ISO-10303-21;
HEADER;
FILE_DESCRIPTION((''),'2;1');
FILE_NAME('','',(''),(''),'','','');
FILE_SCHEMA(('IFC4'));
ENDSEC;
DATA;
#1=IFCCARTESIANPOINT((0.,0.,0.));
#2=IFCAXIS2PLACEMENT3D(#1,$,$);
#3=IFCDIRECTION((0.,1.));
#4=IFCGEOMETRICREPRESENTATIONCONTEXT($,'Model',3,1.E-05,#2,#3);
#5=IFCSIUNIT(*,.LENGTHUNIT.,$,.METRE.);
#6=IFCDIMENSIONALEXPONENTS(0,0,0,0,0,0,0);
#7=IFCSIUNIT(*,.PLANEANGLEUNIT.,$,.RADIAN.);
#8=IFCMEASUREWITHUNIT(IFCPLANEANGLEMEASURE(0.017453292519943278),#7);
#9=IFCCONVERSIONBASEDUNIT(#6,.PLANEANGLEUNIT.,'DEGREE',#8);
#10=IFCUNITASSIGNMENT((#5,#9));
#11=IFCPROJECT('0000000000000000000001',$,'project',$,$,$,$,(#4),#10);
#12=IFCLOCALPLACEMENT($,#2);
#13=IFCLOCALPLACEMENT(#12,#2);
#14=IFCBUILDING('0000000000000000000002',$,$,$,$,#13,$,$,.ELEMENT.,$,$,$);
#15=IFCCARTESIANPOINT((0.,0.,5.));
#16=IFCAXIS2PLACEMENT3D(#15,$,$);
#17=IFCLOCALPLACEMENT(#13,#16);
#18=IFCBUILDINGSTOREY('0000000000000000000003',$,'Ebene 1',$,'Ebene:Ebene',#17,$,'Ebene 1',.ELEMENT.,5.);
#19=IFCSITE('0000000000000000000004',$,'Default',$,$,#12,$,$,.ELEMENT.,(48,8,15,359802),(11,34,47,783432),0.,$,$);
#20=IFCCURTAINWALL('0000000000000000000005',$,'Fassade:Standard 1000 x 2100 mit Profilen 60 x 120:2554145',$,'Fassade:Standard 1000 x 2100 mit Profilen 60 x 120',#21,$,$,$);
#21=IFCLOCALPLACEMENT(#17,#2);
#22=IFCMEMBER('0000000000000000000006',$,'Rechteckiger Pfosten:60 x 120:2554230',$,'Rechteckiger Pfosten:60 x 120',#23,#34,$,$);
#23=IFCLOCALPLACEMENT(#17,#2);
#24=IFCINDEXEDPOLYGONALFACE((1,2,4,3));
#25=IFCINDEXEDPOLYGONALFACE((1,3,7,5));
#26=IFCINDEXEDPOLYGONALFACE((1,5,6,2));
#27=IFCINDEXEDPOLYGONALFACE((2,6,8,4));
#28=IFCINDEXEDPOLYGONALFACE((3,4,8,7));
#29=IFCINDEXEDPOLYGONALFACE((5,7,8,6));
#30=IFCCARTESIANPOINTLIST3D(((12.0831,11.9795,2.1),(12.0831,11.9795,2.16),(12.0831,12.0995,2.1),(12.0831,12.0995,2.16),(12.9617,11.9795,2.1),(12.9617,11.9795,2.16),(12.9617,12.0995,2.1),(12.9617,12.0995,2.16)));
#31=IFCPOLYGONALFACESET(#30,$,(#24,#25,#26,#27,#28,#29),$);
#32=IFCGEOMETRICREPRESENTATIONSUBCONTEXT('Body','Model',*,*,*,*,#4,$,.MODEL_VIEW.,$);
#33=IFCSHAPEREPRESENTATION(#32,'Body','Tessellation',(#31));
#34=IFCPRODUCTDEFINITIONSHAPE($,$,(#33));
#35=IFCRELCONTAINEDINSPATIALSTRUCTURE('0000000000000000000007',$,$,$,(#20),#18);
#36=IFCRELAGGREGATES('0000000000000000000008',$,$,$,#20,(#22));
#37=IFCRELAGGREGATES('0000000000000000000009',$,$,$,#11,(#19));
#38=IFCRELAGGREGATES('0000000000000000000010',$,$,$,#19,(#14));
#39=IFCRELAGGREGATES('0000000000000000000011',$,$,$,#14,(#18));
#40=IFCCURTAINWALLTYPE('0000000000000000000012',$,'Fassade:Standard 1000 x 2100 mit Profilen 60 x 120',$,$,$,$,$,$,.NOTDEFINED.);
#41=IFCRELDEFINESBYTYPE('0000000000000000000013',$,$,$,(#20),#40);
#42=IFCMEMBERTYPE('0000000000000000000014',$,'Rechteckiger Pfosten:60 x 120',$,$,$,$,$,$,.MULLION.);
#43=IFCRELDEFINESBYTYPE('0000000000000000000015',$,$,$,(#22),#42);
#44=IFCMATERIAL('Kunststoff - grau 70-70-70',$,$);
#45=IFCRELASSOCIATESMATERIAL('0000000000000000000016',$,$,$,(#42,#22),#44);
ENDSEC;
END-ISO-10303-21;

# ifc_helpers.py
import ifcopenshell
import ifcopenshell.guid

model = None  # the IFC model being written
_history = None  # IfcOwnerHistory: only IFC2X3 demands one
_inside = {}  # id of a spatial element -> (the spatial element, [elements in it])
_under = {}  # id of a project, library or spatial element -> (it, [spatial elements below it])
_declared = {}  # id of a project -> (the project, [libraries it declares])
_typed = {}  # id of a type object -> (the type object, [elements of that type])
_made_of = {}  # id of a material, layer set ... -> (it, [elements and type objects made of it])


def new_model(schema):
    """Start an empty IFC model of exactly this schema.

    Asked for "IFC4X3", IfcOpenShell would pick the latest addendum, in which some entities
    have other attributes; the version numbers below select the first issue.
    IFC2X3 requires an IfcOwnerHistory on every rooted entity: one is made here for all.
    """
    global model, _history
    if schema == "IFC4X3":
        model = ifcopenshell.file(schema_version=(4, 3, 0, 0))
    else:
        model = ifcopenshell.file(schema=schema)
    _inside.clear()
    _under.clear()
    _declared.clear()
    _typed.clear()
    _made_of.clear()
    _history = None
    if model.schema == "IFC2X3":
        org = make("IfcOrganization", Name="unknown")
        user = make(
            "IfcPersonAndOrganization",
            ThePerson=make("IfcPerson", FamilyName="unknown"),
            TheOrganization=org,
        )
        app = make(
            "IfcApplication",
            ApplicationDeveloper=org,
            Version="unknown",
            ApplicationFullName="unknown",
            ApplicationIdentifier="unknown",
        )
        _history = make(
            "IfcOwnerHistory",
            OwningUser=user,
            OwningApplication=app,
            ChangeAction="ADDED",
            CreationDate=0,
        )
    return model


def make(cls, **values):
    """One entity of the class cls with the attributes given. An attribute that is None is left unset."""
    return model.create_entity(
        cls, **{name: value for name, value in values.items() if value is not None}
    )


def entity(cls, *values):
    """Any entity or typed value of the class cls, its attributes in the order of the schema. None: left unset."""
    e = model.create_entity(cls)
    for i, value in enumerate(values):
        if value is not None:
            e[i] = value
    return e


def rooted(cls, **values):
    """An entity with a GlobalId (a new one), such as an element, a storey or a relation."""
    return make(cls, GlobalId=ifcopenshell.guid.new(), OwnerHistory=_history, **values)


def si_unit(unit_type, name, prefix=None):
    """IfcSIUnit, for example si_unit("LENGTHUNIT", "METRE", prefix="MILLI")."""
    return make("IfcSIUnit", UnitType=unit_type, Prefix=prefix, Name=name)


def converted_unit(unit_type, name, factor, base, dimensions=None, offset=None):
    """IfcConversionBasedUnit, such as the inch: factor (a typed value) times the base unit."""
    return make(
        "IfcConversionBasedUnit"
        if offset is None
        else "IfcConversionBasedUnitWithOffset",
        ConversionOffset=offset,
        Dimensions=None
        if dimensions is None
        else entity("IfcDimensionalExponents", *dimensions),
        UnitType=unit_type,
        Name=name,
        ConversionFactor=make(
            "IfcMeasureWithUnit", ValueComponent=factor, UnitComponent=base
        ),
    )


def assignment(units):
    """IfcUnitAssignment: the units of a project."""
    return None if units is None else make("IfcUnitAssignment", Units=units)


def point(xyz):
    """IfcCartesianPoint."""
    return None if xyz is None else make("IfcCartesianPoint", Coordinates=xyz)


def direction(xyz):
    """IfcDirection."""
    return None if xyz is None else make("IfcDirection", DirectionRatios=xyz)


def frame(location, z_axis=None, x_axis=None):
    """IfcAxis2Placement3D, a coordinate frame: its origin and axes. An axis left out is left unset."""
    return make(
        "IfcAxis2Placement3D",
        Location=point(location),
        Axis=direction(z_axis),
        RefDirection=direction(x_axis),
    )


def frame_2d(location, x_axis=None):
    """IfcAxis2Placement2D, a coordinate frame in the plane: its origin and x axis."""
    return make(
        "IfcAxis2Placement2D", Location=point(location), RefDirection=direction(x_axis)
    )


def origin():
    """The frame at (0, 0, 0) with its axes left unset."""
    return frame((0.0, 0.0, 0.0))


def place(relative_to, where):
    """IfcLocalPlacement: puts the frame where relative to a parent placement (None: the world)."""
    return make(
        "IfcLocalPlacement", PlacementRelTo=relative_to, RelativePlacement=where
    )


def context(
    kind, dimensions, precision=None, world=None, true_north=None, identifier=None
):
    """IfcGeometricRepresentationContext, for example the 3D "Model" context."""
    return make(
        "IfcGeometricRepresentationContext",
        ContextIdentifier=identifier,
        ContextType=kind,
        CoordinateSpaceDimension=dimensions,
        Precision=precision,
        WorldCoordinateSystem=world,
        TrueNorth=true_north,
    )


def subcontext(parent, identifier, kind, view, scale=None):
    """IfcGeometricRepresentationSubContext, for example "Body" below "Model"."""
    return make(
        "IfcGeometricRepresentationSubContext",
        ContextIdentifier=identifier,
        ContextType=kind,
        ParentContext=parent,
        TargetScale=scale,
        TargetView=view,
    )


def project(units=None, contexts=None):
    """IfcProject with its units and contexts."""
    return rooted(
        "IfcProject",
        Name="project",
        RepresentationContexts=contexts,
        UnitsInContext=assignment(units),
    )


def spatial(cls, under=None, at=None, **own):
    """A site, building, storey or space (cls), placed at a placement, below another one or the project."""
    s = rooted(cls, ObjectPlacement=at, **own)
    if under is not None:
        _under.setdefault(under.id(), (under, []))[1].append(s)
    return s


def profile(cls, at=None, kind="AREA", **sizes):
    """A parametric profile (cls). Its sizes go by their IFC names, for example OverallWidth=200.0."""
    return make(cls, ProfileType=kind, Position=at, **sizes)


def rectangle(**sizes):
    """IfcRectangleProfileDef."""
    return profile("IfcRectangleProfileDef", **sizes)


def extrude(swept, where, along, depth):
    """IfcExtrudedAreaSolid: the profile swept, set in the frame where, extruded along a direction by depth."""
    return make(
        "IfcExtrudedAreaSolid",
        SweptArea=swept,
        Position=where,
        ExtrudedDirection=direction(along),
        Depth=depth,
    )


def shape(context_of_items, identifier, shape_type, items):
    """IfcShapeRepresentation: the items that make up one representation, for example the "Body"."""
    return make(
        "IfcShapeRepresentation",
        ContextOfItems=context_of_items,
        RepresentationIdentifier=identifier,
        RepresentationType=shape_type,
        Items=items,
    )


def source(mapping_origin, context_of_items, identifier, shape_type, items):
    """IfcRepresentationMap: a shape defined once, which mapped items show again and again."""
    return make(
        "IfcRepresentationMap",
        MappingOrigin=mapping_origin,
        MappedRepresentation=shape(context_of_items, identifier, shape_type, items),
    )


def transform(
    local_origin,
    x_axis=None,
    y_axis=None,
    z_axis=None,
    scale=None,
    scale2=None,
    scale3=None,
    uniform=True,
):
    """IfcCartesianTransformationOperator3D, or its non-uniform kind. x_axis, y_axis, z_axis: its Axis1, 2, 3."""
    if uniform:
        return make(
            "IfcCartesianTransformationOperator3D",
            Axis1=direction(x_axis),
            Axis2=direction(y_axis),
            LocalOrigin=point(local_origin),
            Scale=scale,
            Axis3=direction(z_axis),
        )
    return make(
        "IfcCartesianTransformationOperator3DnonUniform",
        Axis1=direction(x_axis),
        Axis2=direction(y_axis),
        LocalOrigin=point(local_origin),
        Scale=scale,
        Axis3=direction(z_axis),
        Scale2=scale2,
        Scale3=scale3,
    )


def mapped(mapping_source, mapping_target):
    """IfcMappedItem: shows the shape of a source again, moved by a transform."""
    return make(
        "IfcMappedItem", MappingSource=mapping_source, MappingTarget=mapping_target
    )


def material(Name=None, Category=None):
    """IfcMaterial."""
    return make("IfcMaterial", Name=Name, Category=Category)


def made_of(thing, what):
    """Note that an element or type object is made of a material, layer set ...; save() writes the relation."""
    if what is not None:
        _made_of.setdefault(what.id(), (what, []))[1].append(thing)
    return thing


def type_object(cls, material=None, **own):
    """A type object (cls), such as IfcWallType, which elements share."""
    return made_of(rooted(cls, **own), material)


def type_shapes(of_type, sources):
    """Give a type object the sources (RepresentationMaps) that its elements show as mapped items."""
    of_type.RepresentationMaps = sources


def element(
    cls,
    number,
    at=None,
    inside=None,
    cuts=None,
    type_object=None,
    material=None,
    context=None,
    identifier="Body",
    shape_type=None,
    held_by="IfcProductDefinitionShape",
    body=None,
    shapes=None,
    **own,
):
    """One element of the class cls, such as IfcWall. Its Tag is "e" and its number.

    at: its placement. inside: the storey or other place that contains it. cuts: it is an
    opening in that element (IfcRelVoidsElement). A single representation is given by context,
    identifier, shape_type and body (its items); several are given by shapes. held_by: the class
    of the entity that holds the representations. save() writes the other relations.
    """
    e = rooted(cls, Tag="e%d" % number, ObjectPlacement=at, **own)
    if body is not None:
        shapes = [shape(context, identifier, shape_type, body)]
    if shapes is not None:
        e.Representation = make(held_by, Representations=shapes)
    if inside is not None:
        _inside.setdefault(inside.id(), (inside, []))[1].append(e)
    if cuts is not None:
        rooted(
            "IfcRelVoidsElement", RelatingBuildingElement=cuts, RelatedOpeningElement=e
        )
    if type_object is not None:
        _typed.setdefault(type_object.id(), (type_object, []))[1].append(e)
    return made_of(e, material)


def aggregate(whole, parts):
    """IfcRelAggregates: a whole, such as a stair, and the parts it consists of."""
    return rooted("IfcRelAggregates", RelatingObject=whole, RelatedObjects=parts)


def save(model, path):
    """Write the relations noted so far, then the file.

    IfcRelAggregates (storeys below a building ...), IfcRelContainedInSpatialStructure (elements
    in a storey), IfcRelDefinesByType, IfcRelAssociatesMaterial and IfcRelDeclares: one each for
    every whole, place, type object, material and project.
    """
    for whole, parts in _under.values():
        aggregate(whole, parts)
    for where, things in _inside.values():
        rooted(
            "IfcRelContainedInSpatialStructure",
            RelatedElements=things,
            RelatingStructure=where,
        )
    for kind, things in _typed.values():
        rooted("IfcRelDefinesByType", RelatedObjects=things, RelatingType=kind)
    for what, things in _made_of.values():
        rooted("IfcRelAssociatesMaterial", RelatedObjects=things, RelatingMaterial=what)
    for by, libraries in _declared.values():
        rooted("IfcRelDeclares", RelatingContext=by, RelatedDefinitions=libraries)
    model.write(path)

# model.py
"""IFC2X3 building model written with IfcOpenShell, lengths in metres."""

from ifc_helpers import new_model, entity, si_unit, converted_unit, direction, frame, frame_2d, origin, place, context, subcontext, project, spatial, rectangle, extrude, source, transform, mapped, material, type_object, type_shapes, element, aggregate, save


model = new_model("IFC2X3")

# Units and contexts
model_context = context("Model", 3, precision=1e-05, world=origin(), true_north=direction((0.0, 1.0)))
body_context = subcontext(model_context, "Body", "Model", "MODEL_VIEW")
ifc_project = project(units=[si_unit("LENGTHUNIT", "METRE"), converted_unit("PLANEANGLEUNIT", "DEGREE", entity("IfcPlaneAngleMeasure", 0.017453292519943278), si_unit("PLANEANGLEUNIT", "RADIAN"), dimensions=[0, 0, 0, 0, 0, 0, 0])], contexts=[model_context])

# Site, building, storey
site_placement = place(None, origin())
site = spatial("IfcSite", under=ifc_project, at=site_placement, Name="Default", CompositionType="ELEMENT", RefLatitude=(48, 8, 15, 359802), RefLongitude=(11, 34, 47, 783432), RefElevation=0.0)
building_placement = place(site_placement, origin())
building = spatial("IfcBuilding", under=site, at=building_placement, CompositionType="ELEMENT")
storey_placement = place(building_placement, frame((0.0, 0.0, 5.0)))
storey = spatial("IfcBuildingStorey", under=building, at=storey_placement, Name="Ebene 1", ObjectType="Ebene:Ebene", LongName="Ebene 1", CompositionType="ELEMENT", Elevation=5.0)

# Curtain wall
curtain_wall_type = type_object("IfcCurtainWallType", Name="Fassade:Standard 1000 x 2100 mit Profilen 60 x 120", PredefinedType="NOTDEFINED")
ifc_material_1 = material(Name="Kunststoff - grau 70-70-70")
curtain_wall_1_placement = place(storey_placement, frame((0.0, 0.0, -5.0)))
curtain_wall_1 = element("IfcCurtainWall", 1, at=curtain_wall_1_placement, inside=storey, type_object=curtain_wall_type, Name="Fassade:Standard 1000 x 2100 mit Profilen 60 x 120:2554145", ObjectType="Fassade:Standard 1000 x 2100 mit Profilen 60 x 120")

# Member
member_type_1 = type_object("IfcMemberType", Name="Rechteckiger Pfosten:60 x 120", PredefinedType="MULLION", material=ifc_material_1)
shared_shape_1 = source(origin(), body_context, "Body", "SweptSolid", [
    extrude(rectangle(XDim=0.06, YDim=0.12, at=frame_2d((0.0, 0.0), x_axis=(1.0, 0.0))), frame((0.0, 0.0, -0.8786), z_axis=(0.0, 0.0, 1.0), x_axis=(-1.0, 0.0, 0.0)), (0.0, 0.0, 1.0), 0.8786),
])
type_shapes(member_type_1, [shared_shape_1])
member_1_placement = place(curtain_wall_1_placement, frame((12.0831, 12.0395, 7.13), z_axis=(-1.0, 0.0, 0.0), x_axis=(0.0, 0.0, 1.0)))
member_1 = element("IfcMember", 2, at=member_1_placement, type_object=member_type_1, material=ifc_material_1, Name="Rechteckiger Pfosten:60 x 120:2554230", ObjectType="Rechteckiger Pfosten:60 x 120", context=body_context, shape_type="MappedRepresentation", body=[
    mapped(shared_shape_1, transform((0.0, 0.0, 0.0), scale=1.0)),
])

aggregate(curtain_wall_1, [member_1])

save(model, "model.ifc")
